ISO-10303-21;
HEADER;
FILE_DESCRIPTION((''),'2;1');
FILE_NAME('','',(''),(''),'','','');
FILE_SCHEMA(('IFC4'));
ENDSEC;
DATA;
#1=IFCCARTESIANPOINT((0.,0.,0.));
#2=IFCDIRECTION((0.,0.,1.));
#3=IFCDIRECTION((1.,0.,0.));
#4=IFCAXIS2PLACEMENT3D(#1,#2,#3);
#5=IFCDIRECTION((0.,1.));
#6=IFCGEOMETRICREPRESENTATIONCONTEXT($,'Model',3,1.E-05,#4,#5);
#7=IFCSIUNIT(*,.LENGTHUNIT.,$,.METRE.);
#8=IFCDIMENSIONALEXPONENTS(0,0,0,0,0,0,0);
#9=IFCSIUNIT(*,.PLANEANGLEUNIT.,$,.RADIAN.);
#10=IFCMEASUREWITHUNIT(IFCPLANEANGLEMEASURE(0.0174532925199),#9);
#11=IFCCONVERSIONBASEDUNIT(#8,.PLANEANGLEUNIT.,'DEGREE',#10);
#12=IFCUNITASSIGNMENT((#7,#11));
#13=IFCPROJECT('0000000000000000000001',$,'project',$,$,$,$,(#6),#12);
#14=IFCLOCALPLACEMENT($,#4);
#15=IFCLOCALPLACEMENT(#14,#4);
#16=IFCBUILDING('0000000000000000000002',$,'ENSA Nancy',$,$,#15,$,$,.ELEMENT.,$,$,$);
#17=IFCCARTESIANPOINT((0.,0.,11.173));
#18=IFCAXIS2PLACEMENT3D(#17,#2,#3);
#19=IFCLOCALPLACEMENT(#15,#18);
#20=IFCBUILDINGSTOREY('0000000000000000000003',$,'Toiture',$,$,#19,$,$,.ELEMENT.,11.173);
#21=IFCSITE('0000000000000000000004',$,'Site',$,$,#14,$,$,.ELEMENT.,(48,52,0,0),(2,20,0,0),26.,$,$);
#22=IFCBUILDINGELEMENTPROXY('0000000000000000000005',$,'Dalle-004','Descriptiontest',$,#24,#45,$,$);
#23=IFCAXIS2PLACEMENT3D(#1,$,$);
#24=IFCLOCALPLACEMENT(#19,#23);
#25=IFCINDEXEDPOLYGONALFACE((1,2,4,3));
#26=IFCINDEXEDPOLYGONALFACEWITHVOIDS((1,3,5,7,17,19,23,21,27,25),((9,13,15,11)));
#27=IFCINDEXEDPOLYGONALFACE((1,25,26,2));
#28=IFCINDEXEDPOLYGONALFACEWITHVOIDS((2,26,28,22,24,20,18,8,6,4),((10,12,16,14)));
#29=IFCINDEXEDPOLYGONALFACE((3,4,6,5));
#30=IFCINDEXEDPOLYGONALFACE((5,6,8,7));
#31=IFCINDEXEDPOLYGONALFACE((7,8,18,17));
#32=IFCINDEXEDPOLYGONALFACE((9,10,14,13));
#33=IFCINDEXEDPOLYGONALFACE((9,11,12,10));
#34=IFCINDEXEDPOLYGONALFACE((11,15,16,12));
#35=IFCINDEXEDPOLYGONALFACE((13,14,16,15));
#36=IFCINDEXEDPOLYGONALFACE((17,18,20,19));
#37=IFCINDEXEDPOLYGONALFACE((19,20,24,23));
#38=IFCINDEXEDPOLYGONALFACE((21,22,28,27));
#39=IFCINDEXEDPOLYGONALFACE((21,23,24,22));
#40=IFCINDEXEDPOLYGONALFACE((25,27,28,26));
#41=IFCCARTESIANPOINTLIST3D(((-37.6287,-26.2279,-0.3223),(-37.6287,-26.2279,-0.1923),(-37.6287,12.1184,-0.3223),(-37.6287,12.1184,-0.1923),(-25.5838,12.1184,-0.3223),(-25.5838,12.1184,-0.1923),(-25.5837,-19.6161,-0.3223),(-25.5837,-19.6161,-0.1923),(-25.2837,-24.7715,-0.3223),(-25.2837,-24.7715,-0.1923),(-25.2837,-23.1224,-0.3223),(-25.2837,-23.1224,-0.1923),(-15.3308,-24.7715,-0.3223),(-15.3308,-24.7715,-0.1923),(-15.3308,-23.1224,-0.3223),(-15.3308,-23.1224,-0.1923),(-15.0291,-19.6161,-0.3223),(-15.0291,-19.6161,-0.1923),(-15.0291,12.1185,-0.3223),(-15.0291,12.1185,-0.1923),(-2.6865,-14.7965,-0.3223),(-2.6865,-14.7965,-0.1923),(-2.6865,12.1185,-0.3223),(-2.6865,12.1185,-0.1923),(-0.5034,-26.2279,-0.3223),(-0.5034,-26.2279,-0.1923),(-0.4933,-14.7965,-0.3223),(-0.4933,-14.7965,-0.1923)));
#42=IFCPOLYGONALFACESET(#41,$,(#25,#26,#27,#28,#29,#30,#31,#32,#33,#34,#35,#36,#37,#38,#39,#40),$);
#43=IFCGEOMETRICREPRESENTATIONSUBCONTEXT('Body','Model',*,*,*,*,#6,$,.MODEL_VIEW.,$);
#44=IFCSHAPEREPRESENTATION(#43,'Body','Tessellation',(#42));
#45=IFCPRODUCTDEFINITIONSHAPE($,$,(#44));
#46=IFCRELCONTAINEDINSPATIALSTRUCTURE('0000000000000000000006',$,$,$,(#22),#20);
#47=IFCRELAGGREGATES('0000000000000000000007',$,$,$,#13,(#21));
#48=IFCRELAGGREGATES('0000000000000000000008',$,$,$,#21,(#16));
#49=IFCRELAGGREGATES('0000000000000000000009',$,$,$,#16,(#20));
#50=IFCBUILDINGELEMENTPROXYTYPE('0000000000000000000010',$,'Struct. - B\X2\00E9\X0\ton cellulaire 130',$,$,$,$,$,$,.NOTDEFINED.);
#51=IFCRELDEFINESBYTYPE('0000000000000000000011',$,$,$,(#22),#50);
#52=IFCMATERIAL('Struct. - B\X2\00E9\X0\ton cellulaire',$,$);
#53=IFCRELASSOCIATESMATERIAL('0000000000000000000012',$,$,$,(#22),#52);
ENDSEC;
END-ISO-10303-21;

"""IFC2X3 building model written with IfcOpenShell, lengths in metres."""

from ifc_helpers import new_model, entity, si_unit, converted_unit, direction, frame, origin_with_axes, place, context, subcontext, project, spatial, polyline, outline, extrude, material, type_object, element, save


model = new_model("IFC2X3")

# Units and contexts
model_context = context("Model", 3, precision=1e-05, world=origin_with_axes(), true_north=direction((0.0, 1.0)))
body_context = subcontext(model_context, "Body", "Model", "MODEL_VIEW")
ifc_project = project(units=[si_unit("LENGTHUNIT", "METRE"), converted_unit("PLANEANGLEUNIT", "DEGREE", entity("IfcPlaneAngleMeasure", 0.0174532925199), si_unit("PLANEANGLEUNIT", "RADIAN"), dimensions=[0, 0, 0, 0, 0, 0, 0])], contexts=[model_context])

# Site, building, storey
site_placement = place(None, origin_with_axes())
site = spatial("IfcSite", under=ifc_project, at=site_placement, Name="Site", CompositionType="ELEMENT", RefLatitude=(48, 52, 0, 0), RefLongitude=(2, 20, 0, 0), RefElevation=26.0)
building_placement = place(site_placement, origin_with_axes())
building = spatial("IfcBuilding", under=site, at=building_placement, Name="ENSA Nancy", CompositionType="ELEMENT")
storey_placement = place(building_placement, frame((0.0, 0.0, 11.173), z_axis=(0.0, 0.0, 1.0), x_axis=(1.0, 0.0, 0.0)))
storey = spatial("IfcBuildingStorey", under=building, at=storey_placement, Name="Toiture", CompositionType="ELEMENT", Elevation=11.173)

# Building element proxy, opening
ifc_material = material(Name="Struct. - Béton cellulaire")
building_element_proxy_type = type_object("IfcBuildingElementProxyType", Name="Struct. - Béton cellulaire 130", PredefinedType="NOTDEFINED")
proxy_placement = place(storey_placement, frame((-25.5838, 12.1184, -0.1923), z_axis=(0.0, 0.0, 1.0), x_axis=(1.0, 0.0, 0.0)))
proxy = element("IfcBuildingElementProxy", 1, at=proxy_placement, inside=storey, type_object=building_element_proxy_type, material=ifc_material, Name="Dalle-004", Description="Descriptiontest", context=body_context, shape_type="SweptSolid", body=[
    extrude(outline(polyline([(0.0, 0.0), (-12.0449, 0.0), (-12.0449, -38.3463), (25.0803, -38.3463), (25.0904, -26.915), (22.8973, -26.915), (22.8973, 0.0001), (10.5546, 0.0001), (10.5547, -31.7345), (0.0, -31.7345), (0.0, 0.0)])), frame((0.0, 0.0, -0.13), z_axis=(0.0, 0.0, 1.0), x_axis=(1.0, 0.0, 0.0)), (0.0, 0.0, 1.0), 0.13),
])
opening_placement = place(proxy_placement, frame((10.253, -36.89, 0.0), z_axis=(0.0, 0.0, 1.0), x_axis=(0.0, 1.0, 0.0)))
element("IfcOpeningElement", 2, at=opening_placement, cuts=proxy, context=body_context, shape_type="SweptSolid", body=[
    extrude(outline(polyline([(0.0, 0.0), (1.6492, 0.0), (1.6492, 9.9529), (0.0, 9.9529), (0.0, 0.0)])), frame((0.0, 0.0, -0.13), z_axis=(0.0, 0.0, 1.0), x_axis=(1.0, 0.0, 0.0)), (0.0, 0.0, 1.0), 0.13),
])

save(model, "model.ifc")
